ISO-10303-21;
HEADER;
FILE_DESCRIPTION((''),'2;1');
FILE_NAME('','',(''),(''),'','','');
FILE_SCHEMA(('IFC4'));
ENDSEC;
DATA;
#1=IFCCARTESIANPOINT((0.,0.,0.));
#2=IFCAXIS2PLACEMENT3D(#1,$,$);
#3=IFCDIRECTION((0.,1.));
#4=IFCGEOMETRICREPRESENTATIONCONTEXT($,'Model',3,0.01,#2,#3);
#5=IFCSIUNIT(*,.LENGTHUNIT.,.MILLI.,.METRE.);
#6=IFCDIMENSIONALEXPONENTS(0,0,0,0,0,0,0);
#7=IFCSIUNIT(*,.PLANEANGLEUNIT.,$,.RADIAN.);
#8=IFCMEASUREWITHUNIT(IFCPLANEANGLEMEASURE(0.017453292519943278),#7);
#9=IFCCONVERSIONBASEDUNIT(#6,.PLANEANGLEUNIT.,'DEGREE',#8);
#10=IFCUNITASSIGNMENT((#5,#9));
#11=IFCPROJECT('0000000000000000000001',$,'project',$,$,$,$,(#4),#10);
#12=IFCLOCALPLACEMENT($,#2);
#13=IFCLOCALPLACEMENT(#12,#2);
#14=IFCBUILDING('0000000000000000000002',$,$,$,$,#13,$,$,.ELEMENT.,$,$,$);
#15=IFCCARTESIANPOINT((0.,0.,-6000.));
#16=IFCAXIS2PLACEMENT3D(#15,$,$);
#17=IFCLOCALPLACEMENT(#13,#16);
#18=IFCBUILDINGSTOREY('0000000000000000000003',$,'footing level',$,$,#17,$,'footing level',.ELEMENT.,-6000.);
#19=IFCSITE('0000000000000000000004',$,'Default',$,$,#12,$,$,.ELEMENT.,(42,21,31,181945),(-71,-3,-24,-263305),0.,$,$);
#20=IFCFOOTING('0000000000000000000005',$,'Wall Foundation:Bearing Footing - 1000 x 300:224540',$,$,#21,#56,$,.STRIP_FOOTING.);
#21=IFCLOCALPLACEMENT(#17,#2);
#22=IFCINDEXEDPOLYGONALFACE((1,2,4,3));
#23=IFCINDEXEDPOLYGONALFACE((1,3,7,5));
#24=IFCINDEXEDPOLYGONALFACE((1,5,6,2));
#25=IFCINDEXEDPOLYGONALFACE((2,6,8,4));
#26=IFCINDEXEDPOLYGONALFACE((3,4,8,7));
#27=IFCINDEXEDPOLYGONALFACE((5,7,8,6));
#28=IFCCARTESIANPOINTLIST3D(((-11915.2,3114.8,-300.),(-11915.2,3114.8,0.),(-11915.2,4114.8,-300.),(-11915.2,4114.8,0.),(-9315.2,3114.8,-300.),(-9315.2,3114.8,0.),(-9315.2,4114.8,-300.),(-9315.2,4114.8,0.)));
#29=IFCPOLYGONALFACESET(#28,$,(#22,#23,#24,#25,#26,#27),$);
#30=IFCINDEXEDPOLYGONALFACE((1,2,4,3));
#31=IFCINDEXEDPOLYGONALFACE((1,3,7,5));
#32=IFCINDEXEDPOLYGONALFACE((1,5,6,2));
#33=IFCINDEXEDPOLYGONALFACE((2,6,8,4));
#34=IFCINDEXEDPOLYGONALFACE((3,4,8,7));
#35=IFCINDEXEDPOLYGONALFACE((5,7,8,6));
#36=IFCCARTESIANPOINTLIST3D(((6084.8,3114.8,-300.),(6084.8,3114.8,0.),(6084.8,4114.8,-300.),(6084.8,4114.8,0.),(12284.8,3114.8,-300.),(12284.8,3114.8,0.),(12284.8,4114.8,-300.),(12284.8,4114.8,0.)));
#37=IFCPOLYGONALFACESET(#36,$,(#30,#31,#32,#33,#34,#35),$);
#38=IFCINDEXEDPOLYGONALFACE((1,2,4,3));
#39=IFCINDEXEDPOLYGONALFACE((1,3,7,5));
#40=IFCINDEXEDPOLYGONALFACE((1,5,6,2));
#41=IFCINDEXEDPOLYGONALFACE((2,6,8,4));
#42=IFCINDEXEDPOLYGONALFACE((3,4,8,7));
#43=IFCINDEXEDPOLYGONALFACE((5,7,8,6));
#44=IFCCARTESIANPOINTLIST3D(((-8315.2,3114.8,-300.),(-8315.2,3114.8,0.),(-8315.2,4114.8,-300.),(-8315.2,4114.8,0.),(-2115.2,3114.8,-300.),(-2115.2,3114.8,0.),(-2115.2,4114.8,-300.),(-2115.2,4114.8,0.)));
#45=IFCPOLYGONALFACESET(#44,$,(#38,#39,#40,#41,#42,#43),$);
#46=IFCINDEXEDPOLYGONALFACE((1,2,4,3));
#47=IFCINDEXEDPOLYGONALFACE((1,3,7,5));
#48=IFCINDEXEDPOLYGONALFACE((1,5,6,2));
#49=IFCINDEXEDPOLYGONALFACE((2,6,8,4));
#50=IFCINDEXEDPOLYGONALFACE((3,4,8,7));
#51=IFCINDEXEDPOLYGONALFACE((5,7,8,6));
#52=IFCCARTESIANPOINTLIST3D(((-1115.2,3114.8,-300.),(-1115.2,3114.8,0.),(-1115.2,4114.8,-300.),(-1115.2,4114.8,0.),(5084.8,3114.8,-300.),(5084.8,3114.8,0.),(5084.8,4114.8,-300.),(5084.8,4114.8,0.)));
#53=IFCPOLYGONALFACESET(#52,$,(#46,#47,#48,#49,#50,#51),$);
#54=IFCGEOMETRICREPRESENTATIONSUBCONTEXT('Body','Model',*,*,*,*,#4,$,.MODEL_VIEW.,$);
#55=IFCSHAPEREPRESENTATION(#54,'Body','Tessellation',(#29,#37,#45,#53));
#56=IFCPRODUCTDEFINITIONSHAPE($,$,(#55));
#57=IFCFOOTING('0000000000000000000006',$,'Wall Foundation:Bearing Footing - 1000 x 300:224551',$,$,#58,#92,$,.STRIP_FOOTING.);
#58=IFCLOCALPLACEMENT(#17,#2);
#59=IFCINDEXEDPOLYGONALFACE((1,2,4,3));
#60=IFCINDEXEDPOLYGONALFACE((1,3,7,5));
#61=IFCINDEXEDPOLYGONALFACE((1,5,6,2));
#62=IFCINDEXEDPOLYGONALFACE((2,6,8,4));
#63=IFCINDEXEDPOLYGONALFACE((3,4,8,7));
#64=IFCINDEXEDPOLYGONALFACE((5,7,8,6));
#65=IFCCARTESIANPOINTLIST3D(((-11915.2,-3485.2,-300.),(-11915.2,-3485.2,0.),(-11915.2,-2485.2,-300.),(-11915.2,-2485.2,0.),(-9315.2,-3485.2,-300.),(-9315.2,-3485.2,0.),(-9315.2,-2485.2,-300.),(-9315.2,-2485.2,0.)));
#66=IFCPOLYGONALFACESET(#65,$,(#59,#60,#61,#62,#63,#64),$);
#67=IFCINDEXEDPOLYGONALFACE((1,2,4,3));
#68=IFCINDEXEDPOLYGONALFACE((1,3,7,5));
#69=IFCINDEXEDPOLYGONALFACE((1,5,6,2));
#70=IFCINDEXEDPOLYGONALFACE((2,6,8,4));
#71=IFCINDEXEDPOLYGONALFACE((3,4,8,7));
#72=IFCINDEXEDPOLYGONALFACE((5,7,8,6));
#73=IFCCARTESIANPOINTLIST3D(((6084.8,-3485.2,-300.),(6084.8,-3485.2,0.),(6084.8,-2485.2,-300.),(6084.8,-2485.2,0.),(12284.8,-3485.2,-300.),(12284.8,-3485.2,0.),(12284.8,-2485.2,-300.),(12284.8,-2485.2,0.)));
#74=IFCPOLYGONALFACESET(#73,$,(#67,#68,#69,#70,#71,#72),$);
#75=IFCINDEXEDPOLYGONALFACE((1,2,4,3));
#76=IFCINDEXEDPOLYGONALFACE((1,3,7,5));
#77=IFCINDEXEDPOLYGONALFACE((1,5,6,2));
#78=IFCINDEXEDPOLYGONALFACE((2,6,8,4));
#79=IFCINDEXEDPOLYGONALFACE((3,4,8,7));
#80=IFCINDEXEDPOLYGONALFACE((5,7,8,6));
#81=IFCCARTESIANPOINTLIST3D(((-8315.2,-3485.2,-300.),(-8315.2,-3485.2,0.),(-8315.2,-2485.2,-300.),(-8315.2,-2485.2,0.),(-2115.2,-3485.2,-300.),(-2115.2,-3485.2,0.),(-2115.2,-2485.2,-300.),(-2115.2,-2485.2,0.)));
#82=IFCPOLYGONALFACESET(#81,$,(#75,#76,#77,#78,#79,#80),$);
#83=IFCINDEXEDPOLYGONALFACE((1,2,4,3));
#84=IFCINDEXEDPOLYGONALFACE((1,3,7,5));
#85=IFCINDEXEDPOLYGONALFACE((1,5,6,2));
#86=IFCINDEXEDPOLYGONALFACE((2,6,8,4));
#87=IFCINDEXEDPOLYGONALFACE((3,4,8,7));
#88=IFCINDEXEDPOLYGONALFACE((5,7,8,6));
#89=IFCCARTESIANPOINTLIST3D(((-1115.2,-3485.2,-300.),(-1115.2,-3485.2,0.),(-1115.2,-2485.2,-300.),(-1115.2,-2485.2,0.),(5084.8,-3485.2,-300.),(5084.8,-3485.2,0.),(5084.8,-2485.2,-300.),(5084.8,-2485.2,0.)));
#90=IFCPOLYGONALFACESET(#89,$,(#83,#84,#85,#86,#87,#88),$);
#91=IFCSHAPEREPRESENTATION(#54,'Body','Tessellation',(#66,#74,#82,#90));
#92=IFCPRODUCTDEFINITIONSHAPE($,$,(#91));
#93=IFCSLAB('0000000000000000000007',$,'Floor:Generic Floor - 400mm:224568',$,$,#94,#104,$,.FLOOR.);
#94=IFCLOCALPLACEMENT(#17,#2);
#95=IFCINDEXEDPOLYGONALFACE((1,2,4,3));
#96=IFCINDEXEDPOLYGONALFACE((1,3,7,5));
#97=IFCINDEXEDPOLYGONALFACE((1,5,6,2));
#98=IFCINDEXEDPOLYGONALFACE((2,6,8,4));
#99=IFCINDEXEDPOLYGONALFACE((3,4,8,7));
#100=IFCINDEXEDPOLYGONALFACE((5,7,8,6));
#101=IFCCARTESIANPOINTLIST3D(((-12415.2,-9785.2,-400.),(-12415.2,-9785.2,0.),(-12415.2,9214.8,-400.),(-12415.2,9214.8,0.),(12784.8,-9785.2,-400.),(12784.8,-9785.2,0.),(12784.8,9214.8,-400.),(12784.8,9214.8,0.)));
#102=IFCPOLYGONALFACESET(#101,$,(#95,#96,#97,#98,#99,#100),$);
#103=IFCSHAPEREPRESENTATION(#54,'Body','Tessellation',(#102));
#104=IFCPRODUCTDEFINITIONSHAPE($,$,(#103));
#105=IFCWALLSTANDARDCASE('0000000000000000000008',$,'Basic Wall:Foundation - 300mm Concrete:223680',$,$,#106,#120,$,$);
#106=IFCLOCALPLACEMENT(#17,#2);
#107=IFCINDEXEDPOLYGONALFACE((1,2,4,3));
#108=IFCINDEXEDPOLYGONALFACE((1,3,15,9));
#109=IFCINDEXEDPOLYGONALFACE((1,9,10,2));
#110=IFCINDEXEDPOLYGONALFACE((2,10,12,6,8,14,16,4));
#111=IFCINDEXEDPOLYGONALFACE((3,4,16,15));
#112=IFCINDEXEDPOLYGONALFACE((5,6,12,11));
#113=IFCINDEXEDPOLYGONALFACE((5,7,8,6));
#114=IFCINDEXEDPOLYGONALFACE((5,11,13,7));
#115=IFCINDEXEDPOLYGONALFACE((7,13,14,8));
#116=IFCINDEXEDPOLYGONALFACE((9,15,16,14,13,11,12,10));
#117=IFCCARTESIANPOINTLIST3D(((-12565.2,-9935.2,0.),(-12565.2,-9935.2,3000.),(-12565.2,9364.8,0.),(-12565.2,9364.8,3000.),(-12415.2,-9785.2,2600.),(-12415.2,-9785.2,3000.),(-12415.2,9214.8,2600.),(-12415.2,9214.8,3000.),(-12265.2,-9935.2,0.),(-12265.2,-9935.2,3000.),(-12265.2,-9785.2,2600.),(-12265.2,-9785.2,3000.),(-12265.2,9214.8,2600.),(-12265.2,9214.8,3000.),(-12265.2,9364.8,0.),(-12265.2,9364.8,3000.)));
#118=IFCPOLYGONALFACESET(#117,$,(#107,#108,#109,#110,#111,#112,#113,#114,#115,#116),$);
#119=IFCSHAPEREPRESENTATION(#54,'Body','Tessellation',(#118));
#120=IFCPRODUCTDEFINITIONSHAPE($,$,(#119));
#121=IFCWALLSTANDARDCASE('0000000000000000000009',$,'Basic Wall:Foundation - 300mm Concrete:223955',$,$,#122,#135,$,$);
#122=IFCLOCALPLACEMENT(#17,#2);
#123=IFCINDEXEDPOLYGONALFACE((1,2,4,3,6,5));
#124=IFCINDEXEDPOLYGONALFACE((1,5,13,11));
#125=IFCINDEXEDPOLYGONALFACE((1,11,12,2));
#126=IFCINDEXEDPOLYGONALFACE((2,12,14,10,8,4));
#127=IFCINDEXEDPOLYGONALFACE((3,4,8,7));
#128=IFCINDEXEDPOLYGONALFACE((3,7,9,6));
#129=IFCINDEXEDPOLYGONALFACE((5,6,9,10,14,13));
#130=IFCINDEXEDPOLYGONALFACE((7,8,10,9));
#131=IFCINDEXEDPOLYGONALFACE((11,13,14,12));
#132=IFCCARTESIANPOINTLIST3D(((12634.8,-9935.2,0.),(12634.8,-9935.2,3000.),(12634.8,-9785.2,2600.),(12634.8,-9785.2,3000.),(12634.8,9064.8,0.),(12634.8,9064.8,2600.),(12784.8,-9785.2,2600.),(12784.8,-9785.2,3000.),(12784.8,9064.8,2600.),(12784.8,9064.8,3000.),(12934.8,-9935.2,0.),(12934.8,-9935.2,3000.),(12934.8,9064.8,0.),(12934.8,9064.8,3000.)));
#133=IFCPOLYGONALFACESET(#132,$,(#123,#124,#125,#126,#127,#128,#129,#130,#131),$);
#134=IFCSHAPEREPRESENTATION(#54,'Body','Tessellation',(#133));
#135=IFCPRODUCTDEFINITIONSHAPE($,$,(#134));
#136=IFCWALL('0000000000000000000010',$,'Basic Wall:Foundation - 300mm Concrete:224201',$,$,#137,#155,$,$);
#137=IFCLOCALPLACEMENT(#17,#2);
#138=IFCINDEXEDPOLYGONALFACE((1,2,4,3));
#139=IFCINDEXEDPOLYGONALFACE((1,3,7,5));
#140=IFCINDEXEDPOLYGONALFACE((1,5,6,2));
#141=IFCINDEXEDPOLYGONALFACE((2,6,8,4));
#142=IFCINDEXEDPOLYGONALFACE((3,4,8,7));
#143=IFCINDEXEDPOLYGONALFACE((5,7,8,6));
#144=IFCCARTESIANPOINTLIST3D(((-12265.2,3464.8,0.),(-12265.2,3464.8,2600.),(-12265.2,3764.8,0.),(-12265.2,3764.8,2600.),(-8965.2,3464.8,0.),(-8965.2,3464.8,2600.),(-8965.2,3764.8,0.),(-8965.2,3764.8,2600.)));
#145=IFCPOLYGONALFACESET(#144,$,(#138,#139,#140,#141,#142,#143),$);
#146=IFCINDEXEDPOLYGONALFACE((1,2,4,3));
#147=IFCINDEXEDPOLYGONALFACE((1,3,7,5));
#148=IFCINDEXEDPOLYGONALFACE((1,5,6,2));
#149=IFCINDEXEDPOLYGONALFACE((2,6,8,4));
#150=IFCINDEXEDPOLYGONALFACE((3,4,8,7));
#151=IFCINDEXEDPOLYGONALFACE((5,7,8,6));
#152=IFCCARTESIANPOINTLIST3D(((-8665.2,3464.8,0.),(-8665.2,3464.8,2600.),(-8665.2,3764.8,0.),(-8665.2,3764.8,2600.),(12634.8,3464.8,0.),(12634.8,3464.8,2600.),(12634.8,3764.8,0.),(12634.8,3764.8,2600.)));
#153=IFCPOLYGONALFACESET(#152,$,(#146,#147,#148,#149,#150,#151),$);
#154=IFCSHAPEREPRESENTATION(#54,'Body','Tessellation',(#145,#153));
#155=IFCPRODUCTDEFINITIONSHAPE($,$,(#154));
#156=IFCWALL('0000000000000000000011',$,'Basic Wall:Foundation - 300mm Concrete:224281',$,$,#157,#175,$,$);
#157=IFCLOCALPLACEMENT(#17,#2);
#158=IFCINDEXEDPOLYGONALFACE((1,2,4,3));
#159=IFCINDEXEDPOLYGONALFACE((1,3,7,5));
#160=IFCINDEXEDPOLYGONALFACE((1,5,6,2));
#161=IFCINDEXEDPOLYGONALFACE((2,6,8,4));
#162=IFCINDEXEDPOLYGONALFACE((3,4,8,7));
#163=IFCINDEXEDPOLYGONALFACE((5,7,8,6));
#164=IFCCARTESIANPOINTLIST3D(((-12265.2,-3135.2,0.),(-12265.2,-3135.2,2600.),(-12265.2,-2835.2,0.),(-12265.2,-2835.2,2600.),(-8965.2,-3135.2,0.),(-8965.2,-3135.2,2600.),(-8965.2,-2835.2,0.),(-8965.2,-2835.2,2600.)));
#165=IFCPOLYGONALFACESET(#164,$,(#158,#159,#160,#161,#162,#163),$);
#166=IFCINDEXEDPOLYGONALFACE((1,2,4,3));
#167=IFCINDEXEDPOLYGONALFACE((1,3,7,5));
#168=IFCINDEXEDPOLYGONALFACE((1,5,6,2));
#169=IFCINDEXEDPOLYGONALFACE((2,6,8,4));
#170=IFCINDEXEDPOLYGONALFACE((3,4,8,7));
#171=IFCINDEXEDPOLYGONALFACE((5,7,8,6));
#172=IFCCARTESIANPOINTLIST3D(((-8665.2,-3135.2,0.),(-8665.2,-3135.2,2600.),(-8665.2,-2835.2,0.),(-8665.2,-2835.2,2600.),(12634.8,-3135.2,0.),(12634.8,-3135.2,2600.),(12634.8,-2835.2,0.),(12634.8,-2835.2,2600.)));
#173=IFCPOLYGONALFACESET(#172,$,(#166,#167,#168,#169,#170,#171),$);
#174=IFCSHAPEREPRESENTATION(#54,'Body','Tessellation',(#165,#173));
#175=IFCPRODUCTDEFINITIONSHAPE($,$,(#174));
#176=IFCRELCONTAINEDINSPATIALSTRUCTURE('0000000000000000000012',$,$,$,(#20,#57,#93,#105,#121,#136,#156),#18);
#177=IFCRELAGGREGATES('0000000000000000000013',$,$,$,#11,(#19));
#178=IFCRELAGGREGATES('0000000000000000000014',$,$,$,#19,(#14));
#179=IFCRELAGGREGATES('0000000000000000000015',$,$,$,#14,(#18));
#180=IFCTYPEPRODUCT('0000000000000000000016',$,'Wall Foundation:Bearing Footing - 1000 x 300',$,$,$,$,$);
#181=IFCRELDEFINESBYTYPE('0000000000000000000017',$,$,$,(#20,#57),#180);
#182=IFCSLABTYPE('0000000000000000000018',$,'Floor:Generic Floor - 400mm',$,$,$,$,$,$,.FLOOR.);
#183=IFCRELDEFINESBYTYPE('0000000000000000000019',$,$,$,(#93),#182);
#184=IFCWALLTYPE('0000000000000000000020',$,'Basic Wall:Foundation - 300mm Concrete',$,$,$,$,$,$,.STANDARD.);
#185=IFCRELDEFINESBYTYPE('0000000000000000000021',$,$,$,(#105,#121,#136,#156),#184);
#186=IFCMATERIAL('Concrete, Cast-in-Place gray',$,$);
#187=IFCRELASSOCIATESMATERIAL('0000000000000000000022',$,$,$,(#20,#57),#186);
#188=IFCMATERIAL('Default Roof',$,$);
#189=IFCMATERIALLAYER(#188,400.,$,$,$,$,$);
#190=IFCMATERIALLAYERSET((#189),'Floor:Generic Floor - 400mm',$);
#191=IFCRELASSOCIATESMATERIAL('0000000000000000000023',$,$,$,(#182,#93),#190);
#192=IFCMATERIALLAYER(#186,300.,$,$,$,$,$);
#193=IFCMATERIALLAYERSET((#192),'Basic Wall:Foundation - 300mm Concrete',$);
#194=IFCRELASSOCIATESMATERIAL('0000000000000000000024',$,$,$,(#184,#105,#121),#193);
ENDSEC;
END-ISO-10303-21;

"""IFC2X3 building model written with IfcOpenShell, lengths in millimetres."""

from ifc_helpers import new_model, entity, si_unit, converted_unit, direction, frame, frame_2d, origin, place, context, subcontext, project, spatial, polyline, rectangle, extrude, clip, bounded_halfspace, material, layer, layer_set, layer_usage, type_object, element, save


model = new_model("IFC2X3")

# Units and contexts
model_context = context("Model", 3, precision=0.01, world=origin(), true_north=direction((0.0, 1.0)))
body_context = subcontext(model_context, "Body", "Model", "MODEL_VIEW")
ifc_project = project(units=[si_unit("LENGTHUNIT", "METRE", prefix="MILLI"), converted_unit("PLANEANGLEUNIT", "DEGREE", entity("IfcPlaneAngleMeasure", 0.017453292519943278), si_unit("PLANEANGLEUNIT", "RADIAN"), dimensions=[0, 0, 0, 0, 0, 0, 0])], contexts=[model_context])

# Site, building, storey
site_placement = place(None, origin())
site = spatial("IfcSite", under=ifc_project, at=site_placement, Name="Default", CompositionType="ELEMENT", RefLatitude=(42, 21, 31, 181945), RefLongitude=(-71, -3, -24, -263305), RefElevation=0.0)
building_placement = place(site_placement, origin())
building = spatial("IfcBuilding", under=site, at=building_placement, CompositionType="ELEMENT")
storey_placement = place(building_placement, frame((0.0, 0.0, -6000.0)))
storey = spatial("IfcBuildingStorey", under=building, at=storey_placement, Name="footing level", LongName="footing level", CompositionType="ELEMENT", Elevation=-6000.0)

# Footings
ifc_material_1 = material(Name="Concrete, Cast-in-Place gray")
type_product = type_object("IfcTypeProduct", Name="Wall Foundation:Bearing Footing - 1000 x 300")
footing_1_placement = place(storey_placement, origin())
element("IfcFooting", 1, at=footing_1_placement, inside=storey, type_object=type_product, material=ifc_material_1, Name="Wall Foundation:Bearing Footing - 1000 x 300:224540", PredefinedType="STRIP_FOOTING", context=body_context, shape_type="SweptSolid", body=[
    extrude(rectangle(XDim=2600.0, YDim=1000.0, at=frame_2d((0.0, 0.0), x_axis=(1.0, 0.0))), frame((-10615.2, 3614.8, -300.0)), (0.0, 0.0, 1.0), 300.0),
    extrude(rectangle(XDim=6200.0, YDim=1000.0, at=frame_2d((0.0, 0.0), x_axis=(1.0, 0.0))), frame((9184.8, 3614.8, -300.0), z_axis=(0.0, 0.0, 1.0), x_axis=(-1.0, 0.0, 0.0)), (0.0, 0.0, 1.0), 300.0),
    extrude(rectangle(XDim=6200.0, YDim=1000.0, at=frame_2d((0.0, 0.0), x_axis=(1.0, 0.0))), frame((-5215.2, 3614.8, -300.0)), (0.0, 0.0, 1.0), 300.0),
    extrude(rectangle(XDim=6200.0, YDim=1000.0, at=frame_2d((0.0, 0.0), x_axis=(1.0, 0.0))), frame((1984.8, 3614.8, -300.0)), (0.0, 0.0, 1.0), 300.0),
])
footing_2_placement = place(storey_placement, origin())
element("IfcFooting", 2, at=footing_2_placement, inside=storey, type_object=type_product, material=ifc_material_1, Name="Wall Foundation:Bearing Footing - 1000 x 300:224551", PredefinedType="STRIP_FOOTING", context=body_context, shape_type="SweptSolid", body=[
    extrude(rectangle(XDim=2600.0, YDim=1000.0, at=frame_2d((0.0, 0.0), x_axis=(1.0, 0.0))), frame((-10615.2, -2985.2, -300.0)), (0.0, 0.0, 1.0), 300.0),
    extrude(rectangle(XDim=6200.0, YDim=1000.0, at=frame_2d((0.0, 0.0), x_axis=(1.0, 0.0))), frame((9184.8, -2985.2, -300.0), z_axis=(0.0, 0.0, 1.0), x_axis=(-1.0, 0.0, 0.0)), (0.0, 0.0, 1.0), 300.0),
    extrude(rectangle(XDim=6200.0, YDim=1000.0, at=frame_2d((0.0, 0.0), x_axis=(1.0, 0.0))), frame((-5215.2, -2985.2, -300.0)), (0.0, 0.0, 1.0), 300.0),
    extrude(rectangle(XDim=6200.0, YDim=1000.0, at=frame_2d((0.0, 0.0), x_axis=(1.0, 0.0))), frame((1984.8, -2985.2, -300.0)), (0.0, 0.0, 1.0), 300.0),
])

# Slab
ifc_material_2 = material(Name="Default Roof")
ifc_layer_1 = layer(ifc_material_2, 400.0)
ifc_layer_set_1 = layer_set([ifc_layer_1], Name="Floor:Generic Floor - 400mm")
ifc_layer_usage_1 = layer_usage(ifc_layer_set_1, "AXIS3", "POSITIVE", 0.0)
slab_type = type_object("IfcSlabType", Name="Floor:Generic Floor - 400mm", PredefinedType="FLOOR", material=ifc_layer_set_1)
slab_placement = place(storey_placement, origin())
element("IfcSlab", 3, at=slab_placement, inside=storey, type_object=slab_type, material=ifc_layer_usage_1, Name="Floor:Generic Floor - 400mm:224568", PredefinedType="FLOOR", context=body_context, shape_type="SweptSolid", body=[
    extrude(rectangle(XDim=19000.0, YDim=25200.0, at=frame_2d((0.0, 0.0), x_axis=(1.0, 0.0))), frame((184.8, -285.2, 0.0), z_axis=(0.0, 0.0, -1.0), x_axis=(0.0, 1.0, 0.0)), (0.0, 0.0, 1.0), 400.0),
])

# Walls
ifc_layer_2 = layer(ifc_material_1, 300.0)
ifc_layer_set_2 = layer_set([ifc_layer_2], Name="Basic Wall:Foundation - 300mm Concrete")
ifc_layer_usage_2 = layer_usage(ifc_layer_set_2, "AXIS2", "NEGATIVE", 150.0)
wall_type = type_object("IfcWallType", Name="Basic Wall:Foundation - 300mm Concrete", PredefinedType="STANDARD", material=ifc_layer_set_2)
wall_1_placement = place(storey_placement, frame((-12415.2, -9935.2, 0.0), z_axis=(0.0, 0.0, 1.0), x_axis=(0.0, 1.0, 0.0)))
element("IfcWallStandardCase", 4, at=wall_1_placement, inside=storey, type_object=wall_type, material=ifc_layer_usage_2, Name="Basic Wall:Foundation - 300mm Concrete:223680", context=body_context, shape_type="Clipping", body=[
    clip(extrude(rectangle(XDim=19300.0, YDim=300.0, at=frame_2d((9650.0, 0.0), x_axis=(-1.0, 0.0))), origin(), (0.0, 0.0, 1.0), 3000.0), bounded_halfspace(frame((150.0, -150.0, 2600.0), z_axis=(0.0, 0.0, -1.0), x_axis=(-1.0, 0.0, 0.0)), True, frame((150.0, -150.0, 2600.0)), polyline([(0.0, 0.0), (150.0, 0.0), (6650.0, 0.0), (6950.0, 0.0), (13250.0, 0.0), (13550.0, 0.0), (18850.0, 0.0), (19000.0, 0.0), (19000.0, 150.0), (0.0, 150.0), (0.0, 0.0)]))),
])
ifc_layer_usage_3 = layer_usage(ifc_layer_set_2, "AXIS2", "NEGATIVE", 150.0)
wall_2_placement = place(storey_placement, frame((12784.8, 9064.8, 0.0), z_axis=(0.0, 0.0, 1.0), x_axis=(0.0, -1.0, 0.0)))
element("IfcWallStandardCase", 5, at=wall_2_placement, inside=storey, type_object=wall_type, material=ifc_layer_usage_3, Name="Basic Wall:Foundation - 300mm Concrete:223955", context=body_context, shape_type="Clipping", body=[
    clip(extrude(rectangle(XDim=19000.0, YDim=300.0, at=frame_2d((9500.0, 0.0), x_axis=(-1.0, 0.0))), origin(), (0.0, 0.0, 1.0), 3000.0), bounded_halfspace(frame((0.0, -150.0, 2600.0), z_axis=(0.0, 0.0, -1.0), x_axis=(1.0, 0.0, 0.0)), True, frame((0.0, -150.0, 2600.0)), polyline([(0.0, 0.0), (5300.0, 0.0), (5600.0, 0.0), (11900.0, 0.0), (12200.0, 0.0), (18700.0, 0.0), (18850.0, 0.0), (18850.0, 150.0), (0.0, 150.0), (0.0, 0.0)]))),
])
wall_3_placement = place(storey_placement, frame((-12265.2, 3614.8, 0.0)))
element("IfcWall", 6, at=wall_3_placement, inside=storey, type_object=wall_type, Name="Basic Wall:Foundation - 300mm Concrete:224201", context=body_context, shape_type="SweptSolid", body=[
    extrude(rectangle(XDim=3300.0, YDim=300.0, at=frame_2d((0.0, 0.0), x_axis=(1.0, 0.0))), frame((1650.0, 0.0, 0.0)), (0.0, 0.0, 1.0), 2600.0),
    extrude(rectangle(XDim=21300.0, YDim=300.0, at=frame_2d((0.0, 0.0), x_axis=(1.0, 0.0))), frame((14250.0, 0.0, 0.0), z_axis=(0.0, 0.0, 1.0), x_axis=(-1.0, 0.0, 0.0)), (0.0, 0.0, 1.0), 2600.0),
])
wall_4_placement = place(storey_placement, frame((-12265.2, -2985.2, 0.0)))
element("IfcWall", 7, at=wall_4_placement, inside=storey, type_object=wall_type, Name="Basic Wall:Foundation - 300mm Concrete:224281", context=body_context, shape_type="SweptSolid", body=[
    extrude(rectangle(XDim=3300.0, YDim=300.0, at=frame_2d((0.0, 0.0), x_axis=(1.0, 0.0))), frame((1650.0, 0.0, 0.0)), (0.0, 0.0, 1.0), 2600.0),
    extrude(rectangle(XDim=21300.0, YDim=300.0, at=frame_2d((0.0, 0.0), x_axis=(1.0, 0.0))), frame((14250.0, 0.0, 0.0), z_axis=(0.0, 0.0, 1.0), x_axis=(-1.0, 0.0, 0.0)), (0.0, 0.0, 1.0), 2600.0),
])

save(model, "model.ifc")
